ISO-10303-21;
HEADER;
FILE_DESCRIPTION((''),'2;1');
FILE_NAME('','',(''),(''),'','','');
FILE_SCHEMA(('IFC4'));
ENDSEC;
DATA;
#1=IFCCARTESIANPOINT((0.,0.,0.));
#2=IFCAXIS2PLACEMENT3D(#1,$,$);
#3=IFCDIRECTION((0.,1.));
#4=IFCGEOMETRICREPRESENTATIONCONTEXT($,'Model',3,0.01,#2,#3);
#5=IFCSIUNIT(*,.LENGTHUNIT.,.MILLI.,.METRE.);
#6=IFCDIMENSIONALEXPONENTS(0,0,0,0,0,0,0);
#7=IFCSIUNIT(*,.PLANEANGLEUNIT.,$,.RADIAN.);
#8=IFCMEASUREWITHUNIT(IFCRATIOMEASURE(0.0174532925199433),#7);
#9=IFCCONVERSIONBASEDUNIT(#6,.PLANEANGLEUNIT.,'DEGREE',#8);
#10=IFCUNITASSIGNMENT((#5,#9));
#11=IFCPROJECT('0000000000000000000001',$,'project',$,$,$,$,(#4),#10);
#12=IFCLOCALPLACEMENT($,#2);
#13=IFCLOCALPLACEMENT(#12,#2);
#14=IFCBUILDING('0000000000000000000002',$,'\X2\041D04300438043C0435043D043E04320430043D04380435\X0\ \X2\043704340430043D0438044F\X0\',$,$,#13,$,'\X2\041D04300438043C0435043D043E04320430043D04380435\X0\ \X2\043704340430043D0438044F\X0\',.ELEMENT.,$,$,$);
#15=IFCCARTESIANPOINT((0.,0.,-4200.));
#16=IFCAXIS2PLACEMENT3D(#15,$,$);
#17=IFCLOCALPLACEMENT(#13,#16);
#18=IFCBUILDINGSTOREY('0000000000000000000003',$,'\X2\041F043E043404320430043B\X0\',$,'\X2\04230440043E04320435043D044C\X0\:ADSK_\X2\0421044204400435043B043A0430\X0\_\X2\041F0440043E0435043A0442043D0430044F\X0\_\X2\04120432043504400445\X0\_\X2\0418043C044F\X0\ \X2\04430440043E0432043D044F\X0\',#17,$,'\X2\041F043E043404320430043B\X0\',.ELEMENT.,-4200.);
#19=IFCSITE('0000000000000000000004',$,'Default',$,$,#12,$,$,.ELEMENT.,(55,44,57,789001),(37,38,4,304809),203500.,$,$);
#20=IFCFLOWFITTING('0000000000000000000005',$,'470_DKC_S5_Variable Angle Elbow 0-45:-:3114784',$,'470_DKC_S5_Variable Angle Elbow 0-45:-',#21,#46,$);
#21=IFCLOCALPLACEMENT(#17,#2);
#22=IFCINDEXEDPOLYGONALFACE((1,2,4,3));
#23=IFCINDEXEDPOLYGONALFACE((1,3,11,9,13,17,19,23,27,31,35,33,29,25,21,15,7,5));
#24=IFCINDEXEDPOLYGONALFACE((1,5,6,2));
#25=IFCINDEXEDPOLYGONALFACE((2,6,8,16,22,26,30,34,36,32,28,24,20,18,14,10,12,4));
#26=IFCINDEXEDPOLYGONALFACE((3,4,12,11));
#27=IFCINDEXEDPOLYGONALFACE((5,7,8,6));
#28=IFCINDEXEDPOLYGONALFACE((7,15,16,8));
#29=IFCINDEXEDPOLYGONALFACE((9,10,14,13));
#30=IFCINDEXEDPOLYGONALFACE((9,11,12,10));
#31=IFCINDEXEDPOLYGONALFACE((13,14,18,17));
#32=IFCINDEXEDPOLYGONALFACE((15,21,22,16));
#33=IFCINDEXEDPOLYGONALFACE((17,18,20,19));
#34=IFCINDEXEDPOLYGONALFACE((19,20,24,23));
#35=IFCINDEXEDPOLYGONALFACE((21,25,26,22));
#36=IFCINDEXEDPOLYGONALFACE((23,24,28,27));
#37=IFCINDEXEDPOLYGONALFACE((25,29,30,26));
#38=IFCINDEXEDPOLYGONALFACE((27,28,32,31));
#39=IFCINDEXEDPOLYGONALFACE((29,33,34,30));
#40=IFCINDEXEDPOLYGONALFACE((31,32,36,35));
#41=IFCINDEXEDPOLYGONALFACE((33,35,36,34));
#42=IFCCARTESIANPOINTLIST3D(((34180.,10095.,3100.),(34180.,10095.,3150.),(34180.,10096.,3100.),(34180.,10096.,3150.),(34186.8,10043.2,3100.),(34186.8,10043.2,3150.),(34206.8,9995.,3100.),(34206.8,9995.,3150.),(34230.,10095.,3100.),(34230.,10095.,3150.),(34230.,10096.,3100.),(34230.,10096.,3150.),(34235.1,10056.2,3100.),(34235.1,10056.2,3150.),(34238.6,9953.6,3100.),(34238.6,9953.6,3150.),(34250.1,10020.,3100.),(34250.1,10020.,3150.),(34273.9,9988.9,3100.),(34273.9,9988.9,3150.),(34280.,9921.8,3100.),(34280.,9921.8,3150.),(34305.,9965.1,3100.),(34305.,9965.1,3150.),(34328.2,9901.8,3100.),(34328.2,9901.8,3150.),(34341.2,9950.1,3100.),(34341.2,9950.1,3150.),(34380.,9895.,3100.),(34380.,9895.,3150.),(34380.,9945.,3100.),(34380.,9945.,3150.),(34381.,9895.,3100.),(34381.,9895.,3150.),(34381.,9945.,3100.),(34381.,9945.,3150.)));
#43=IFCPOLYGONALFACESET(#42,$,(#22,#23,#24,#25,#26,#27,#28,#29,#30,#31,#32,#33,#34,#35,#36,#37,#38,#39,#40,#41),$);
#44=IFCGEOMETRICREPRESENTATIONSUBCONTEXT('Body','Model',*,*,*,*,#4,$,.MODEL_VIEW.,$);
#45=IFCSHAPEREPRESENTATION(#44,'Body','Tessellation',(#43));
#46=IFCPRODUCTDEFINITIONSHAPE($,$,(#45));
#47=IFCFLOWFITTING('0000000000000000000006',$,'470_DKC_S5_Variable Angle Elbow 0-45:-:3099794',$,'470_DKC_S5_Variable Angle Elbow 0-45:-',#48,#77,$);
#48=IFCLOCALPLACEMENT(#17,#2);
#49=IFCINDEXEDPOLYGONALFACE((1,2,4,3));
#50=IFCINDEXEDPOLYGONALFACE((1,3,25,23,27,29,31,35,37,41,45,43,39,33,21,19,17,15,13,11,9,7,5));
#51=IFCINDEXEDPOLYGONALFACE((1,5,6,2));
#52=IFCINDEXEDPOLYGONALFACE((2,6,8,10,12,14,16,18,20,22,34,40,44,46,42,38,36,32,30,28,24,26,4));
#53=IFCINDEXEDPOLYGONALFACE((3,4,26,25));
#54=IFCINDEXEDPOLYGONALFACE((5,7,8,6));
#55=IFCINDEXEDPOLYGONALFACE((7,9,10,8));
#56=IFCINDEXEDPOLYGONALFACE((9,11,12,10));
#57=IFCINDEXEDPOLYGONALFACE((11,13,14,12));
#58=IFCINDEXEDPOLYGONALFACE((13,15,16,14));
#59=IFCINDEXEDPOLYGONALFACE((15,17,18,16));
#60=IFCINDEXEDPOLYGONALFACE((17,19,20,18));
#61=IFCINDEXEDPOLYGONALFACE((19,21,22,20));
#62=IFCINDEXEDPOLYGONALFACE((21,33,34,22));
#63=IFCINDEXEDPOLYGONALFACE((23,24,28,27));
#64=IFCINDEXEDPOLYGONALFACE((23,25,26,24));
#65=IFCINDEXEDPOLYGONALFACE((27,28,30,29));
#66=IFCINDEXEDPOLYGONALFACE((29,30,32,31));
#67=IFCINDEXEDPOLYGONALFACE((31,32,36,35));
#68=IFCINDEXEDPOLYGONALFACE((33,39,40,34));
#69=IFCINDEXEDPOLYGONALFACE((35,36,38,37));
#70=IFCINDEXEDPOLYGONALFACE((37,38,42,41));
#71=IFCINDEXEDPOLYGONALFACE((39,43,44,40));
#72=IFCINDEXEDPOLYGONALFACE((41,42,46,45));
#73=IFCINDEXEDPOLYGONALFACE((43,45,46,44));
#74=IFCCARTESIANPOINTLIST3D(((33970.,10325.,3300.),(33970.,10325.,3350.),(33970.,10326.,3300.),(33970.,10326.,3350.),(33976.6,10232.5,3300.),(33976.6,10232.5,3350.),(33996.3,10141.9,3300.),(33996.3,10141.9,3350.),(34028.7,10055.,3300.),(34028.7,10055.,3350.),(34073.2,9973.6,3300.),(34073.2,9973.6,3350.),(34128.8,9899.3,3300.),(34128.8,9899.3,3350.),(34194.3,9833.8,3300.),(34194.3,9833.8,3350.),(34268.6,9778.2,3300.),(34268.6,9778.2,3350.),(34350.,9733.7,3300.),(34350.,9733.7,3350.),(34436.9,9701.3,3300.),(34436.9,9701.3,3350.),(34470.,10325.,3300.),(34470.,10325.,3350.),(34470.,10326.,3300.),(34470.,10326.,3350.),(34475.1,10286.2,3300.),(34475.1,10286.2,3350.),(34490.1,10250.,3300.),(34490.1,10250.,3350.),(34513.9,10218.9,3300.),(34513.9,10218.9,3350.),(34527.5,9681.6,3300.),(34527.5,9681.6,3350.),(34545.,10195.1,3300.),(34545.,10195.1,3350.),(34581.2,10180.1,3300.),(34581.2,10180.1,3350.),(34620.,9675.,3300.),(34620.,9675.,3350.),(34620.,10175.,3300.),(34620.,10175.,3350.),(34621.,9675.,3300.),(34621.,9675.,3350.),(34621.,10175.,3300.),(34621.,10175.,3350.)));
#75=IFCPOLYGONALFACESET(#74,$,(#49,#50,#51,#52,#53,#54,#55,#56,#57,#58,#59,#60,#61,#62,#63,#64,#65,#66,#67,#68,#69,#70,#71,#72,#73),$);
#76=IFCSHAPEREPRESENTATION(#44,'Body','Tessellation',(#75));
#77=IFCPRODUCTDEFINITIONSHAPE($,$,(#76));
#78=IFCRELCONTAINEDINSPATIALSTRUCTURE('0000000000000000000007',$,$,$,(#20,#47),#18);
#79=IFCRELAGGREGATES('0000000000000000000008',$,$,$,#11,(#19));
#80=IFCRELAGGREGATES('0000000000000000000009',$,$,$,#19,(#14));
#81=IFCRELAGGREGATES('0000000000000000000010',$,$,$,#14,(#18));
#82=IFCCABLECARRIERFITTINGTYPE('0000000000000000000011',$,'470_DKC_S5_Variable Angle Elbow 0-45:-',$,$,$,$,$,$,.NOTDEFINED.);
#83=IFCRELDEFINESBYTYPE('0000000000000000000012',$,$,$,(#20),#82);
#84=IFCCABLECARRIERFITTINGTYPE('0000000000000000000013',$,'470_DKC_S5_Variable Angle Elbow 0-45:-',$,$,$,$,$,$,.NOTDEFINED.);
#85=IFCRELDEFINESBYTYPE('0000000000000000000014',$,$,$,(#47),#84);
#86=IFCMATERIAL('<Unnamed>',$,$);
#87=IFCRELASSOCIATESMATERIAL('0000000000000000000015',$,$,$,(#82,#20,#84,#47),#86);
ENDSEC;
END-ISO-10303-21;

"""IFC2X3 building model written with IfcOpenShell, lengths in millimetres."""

from ifc_helpers import new_model, entity, si_unit, converted_unit, direction, frame, frame_2d, origin, place, context, subcontext, project, spatial, polyline, circle_curve, parameter, trimmed, segment, composite_curve, outline, extrude, source, transform, mapped, material, type_object, type_shapes, element, save


model = new_model("IFC2X3")

# Units and contexts
model_context = context("Model", 3, precision=0.01, world=origin(), true_north=direction((0.0, 1.0)))
body_context = subcontext(model_context, "Body", "Model", "MODEL_VIEW")
ifc_project = project(units=[si_unit("LENGTHUNIT", "METRE", prefix="MILLI"), converted_unit("PLANEANGLEUNIT", "DEGREE", entity("IfcRatioMeasure", 0.0174532925199433), si_unit("PLANEANGLEUNIT", "RADIAN"), dimensions=[0, 0, 0, 0, 0, 0, 0])], contexts=[model_context])

# Site, building, storey
site_placement = place(None, origin())
site = spatial("IfcSite", under=ifc_project, at=site_placement, Name="Default", CompositionType="ELEMENT", RefLatitude=(55, 44, 57, 789001), RefLongitude=(37, 38, 4, 304809), RefElevation=203500.0)
building_placement = place(site_placement, origin())
building = spatial("IfcBuilding", under=site, at=building_placement, Name="Наименование здания", LongName="Наименование здания", CompositionType="ELEMENT")
storey_placement = place(building_placement, frame((0.0, 0.0, -4200.0)))
storey = spatial("IfcBuildingStorey", under=building, at=storey_placement, Name="Подвал", ObjectType="Уровень:ADSK_Стрелка_Проектная_Вверх_Имя уровня", LongName="Подвал", CompositionType="ELEMENT", Elevation=-4200.0)

# Flow fittings
ifc_material_1 = material(Name="<Unnamed>")
cable_carrier_fitting_type_1 = type_object("IfcCableCarrierFittingType", Name="470_DKC_S5_Variable Angle Elbow 0-45:-", PredefinedType="NOTDEFINED", material=ifc_material_1)
shared_shape_1 = source(origin(), body_context, "Body", "SweptSolid", [
    extrude(outline(composite_curve([segment(polyline([(-88.2, -112.8), (-87.2, -112.8)]), True, "CONTINUOUS"), segment(trimmed(circle_curve(frame_2d((-87.2, 87.2), x_axis=(0.0, -1.0)), 200.0), [parameter(0.0)], [parameter(90.0)], True, "PARAMETER"), True, "CONTINUOUS"), segment(polyline([(112.8, 87.2), (112.8, 88.2)]), True, "CONTINUOUS"), segment(polyline([(112.8, 88.2), (62.8, 88.2)]), True, "CONTINUOUS"), segment(polyline([(62.8, 88.2), (62.8, 87.2)]), True, "CONTINUOUS"), segment(trimmed(circle_curve(frame_2d((-87.2, 87.2), x_axis=(0.0, -1.0)), 150.0), [parameter(0.0)], [parameter(90.0)], True, "PARAMETER"), False, "CONTINUOUS"), segment(polyline([(-87.2, -62.8), (-88.2, -62.8)]), True, "CONTINUOUS"), segment(polyline([(-88.2, -62.8), (-88.2, -112.8)]), True, "CONTINUOUS")], self_intersect=False)), frame((-87.8, 87.8, -25.0)), (0.0, 0.0, 1.0), 50.0),
])
type_shapes(cable_carrier_fitting_type_1, [shared_shape_1])
flow_fitting_1_placement = place(storey_placement, frame((34205.0, 9920.0, 3125.0), z_axis=(0.0, 0.0, 1.0), x_axis=(0.0, -1.0, 0.0)))
element("IfcFlowFitting", 1, at=flow_fitting_1_placement, inside=storey, type_object=cable_carrier_fitting_type_1, material=ifc_material_1, Name="470_DKC_S5_Variable Angle Elbow 0-45:-:3114784", ObjectType="470_DKC_S5_Variable Angle Elbow 0-45:-", context=body_context, shape_type="MappedRepresentation", body=[
    mapped(shared_shape_1, transform((0.0, 0.0, 0.0), scale=1.0)),
])
cable_carrier_fitting_type_2 = type_object("IfcCableCarrierFittingType", Name="470_DKC_S5_Variable Angle Elbow 0-45:-", PredefinedType="NOTDEFINED", material=ifc_material_1)
shared_shape_2 = source(origin(), body_context, "Body", "SweptSolid", [
    extrude(outline(composite_curve([segment(polyline([(-200.8, -450.2), (-199.8, -450.2)]), True, "CONTINUOUS"), segment(trimmed(circle_curve(frame_2d((-199.8, 199.8), x_axis=(0.0, -1.0)), 650.0), [parameter(0.0)], [parameter(90.0)], True, "PARAMETER"), True, "CONTINUOUS"), segment(polyline([(450.2, 199.8), (450.2, 200.8)]), True, "CONTINUOUS"), segment(polyline([(450.2, 200.8), (-49.8, 200.8)]), True, "CONTINUOUS"), segment(polyline([(-49.8, 200.8), (-49.8, 199.8)]), True, "CONTINUOUS"), segment(trimmed(circle_curve(frame_2d((-199.8, 199.8), x_axis=(0.0, -1.0)), 150.0), [parameter(0.0)], [parameter(90.0)], True, "PARAMETER"), False, "CONTINUOUS"), segment(polyline([(-199.8, 49.8), (-200.8, 49.8)]), True, "CONTINUOUS"), segment(polyline([(-200.8, 49.8), (-200.8, -450.2)]), True, "CONTINUOUS")], self_intersect=False)), frame((-200.2, 200.2, -25.0)), (0.0, 0.0, 1.0), 50.0),
])
type_shapes(cable_carrier_fitting_type_2, [shared_shape_2])
flow_fitting_2_placement = place(storey_placement, frame((34220.0, 9925.0, 3325.0), z_axis=(0.0, 0.0, 1.0), x_axis=(0.0, -1.0, 0.0)))
element("IfcFlowFitting", 2, at=flow_fitting_2_placement, inside=storey, type_object=cable_carrier_fitting_type_2, material=ifc_material_1, Name="470_DKC_S5_Variable Angle Elbow 0-45:-:3099794", ObjectType="470_DKC_S5_Variable Angle Elbow 0-45:-", context=body_context, shape_type="MappedRepresentation", body=[
    mapped(shared_shape_2, transform((0.0, 0.0, 0.0), scale=1.0)),
])

save(model, "model.ifc")
